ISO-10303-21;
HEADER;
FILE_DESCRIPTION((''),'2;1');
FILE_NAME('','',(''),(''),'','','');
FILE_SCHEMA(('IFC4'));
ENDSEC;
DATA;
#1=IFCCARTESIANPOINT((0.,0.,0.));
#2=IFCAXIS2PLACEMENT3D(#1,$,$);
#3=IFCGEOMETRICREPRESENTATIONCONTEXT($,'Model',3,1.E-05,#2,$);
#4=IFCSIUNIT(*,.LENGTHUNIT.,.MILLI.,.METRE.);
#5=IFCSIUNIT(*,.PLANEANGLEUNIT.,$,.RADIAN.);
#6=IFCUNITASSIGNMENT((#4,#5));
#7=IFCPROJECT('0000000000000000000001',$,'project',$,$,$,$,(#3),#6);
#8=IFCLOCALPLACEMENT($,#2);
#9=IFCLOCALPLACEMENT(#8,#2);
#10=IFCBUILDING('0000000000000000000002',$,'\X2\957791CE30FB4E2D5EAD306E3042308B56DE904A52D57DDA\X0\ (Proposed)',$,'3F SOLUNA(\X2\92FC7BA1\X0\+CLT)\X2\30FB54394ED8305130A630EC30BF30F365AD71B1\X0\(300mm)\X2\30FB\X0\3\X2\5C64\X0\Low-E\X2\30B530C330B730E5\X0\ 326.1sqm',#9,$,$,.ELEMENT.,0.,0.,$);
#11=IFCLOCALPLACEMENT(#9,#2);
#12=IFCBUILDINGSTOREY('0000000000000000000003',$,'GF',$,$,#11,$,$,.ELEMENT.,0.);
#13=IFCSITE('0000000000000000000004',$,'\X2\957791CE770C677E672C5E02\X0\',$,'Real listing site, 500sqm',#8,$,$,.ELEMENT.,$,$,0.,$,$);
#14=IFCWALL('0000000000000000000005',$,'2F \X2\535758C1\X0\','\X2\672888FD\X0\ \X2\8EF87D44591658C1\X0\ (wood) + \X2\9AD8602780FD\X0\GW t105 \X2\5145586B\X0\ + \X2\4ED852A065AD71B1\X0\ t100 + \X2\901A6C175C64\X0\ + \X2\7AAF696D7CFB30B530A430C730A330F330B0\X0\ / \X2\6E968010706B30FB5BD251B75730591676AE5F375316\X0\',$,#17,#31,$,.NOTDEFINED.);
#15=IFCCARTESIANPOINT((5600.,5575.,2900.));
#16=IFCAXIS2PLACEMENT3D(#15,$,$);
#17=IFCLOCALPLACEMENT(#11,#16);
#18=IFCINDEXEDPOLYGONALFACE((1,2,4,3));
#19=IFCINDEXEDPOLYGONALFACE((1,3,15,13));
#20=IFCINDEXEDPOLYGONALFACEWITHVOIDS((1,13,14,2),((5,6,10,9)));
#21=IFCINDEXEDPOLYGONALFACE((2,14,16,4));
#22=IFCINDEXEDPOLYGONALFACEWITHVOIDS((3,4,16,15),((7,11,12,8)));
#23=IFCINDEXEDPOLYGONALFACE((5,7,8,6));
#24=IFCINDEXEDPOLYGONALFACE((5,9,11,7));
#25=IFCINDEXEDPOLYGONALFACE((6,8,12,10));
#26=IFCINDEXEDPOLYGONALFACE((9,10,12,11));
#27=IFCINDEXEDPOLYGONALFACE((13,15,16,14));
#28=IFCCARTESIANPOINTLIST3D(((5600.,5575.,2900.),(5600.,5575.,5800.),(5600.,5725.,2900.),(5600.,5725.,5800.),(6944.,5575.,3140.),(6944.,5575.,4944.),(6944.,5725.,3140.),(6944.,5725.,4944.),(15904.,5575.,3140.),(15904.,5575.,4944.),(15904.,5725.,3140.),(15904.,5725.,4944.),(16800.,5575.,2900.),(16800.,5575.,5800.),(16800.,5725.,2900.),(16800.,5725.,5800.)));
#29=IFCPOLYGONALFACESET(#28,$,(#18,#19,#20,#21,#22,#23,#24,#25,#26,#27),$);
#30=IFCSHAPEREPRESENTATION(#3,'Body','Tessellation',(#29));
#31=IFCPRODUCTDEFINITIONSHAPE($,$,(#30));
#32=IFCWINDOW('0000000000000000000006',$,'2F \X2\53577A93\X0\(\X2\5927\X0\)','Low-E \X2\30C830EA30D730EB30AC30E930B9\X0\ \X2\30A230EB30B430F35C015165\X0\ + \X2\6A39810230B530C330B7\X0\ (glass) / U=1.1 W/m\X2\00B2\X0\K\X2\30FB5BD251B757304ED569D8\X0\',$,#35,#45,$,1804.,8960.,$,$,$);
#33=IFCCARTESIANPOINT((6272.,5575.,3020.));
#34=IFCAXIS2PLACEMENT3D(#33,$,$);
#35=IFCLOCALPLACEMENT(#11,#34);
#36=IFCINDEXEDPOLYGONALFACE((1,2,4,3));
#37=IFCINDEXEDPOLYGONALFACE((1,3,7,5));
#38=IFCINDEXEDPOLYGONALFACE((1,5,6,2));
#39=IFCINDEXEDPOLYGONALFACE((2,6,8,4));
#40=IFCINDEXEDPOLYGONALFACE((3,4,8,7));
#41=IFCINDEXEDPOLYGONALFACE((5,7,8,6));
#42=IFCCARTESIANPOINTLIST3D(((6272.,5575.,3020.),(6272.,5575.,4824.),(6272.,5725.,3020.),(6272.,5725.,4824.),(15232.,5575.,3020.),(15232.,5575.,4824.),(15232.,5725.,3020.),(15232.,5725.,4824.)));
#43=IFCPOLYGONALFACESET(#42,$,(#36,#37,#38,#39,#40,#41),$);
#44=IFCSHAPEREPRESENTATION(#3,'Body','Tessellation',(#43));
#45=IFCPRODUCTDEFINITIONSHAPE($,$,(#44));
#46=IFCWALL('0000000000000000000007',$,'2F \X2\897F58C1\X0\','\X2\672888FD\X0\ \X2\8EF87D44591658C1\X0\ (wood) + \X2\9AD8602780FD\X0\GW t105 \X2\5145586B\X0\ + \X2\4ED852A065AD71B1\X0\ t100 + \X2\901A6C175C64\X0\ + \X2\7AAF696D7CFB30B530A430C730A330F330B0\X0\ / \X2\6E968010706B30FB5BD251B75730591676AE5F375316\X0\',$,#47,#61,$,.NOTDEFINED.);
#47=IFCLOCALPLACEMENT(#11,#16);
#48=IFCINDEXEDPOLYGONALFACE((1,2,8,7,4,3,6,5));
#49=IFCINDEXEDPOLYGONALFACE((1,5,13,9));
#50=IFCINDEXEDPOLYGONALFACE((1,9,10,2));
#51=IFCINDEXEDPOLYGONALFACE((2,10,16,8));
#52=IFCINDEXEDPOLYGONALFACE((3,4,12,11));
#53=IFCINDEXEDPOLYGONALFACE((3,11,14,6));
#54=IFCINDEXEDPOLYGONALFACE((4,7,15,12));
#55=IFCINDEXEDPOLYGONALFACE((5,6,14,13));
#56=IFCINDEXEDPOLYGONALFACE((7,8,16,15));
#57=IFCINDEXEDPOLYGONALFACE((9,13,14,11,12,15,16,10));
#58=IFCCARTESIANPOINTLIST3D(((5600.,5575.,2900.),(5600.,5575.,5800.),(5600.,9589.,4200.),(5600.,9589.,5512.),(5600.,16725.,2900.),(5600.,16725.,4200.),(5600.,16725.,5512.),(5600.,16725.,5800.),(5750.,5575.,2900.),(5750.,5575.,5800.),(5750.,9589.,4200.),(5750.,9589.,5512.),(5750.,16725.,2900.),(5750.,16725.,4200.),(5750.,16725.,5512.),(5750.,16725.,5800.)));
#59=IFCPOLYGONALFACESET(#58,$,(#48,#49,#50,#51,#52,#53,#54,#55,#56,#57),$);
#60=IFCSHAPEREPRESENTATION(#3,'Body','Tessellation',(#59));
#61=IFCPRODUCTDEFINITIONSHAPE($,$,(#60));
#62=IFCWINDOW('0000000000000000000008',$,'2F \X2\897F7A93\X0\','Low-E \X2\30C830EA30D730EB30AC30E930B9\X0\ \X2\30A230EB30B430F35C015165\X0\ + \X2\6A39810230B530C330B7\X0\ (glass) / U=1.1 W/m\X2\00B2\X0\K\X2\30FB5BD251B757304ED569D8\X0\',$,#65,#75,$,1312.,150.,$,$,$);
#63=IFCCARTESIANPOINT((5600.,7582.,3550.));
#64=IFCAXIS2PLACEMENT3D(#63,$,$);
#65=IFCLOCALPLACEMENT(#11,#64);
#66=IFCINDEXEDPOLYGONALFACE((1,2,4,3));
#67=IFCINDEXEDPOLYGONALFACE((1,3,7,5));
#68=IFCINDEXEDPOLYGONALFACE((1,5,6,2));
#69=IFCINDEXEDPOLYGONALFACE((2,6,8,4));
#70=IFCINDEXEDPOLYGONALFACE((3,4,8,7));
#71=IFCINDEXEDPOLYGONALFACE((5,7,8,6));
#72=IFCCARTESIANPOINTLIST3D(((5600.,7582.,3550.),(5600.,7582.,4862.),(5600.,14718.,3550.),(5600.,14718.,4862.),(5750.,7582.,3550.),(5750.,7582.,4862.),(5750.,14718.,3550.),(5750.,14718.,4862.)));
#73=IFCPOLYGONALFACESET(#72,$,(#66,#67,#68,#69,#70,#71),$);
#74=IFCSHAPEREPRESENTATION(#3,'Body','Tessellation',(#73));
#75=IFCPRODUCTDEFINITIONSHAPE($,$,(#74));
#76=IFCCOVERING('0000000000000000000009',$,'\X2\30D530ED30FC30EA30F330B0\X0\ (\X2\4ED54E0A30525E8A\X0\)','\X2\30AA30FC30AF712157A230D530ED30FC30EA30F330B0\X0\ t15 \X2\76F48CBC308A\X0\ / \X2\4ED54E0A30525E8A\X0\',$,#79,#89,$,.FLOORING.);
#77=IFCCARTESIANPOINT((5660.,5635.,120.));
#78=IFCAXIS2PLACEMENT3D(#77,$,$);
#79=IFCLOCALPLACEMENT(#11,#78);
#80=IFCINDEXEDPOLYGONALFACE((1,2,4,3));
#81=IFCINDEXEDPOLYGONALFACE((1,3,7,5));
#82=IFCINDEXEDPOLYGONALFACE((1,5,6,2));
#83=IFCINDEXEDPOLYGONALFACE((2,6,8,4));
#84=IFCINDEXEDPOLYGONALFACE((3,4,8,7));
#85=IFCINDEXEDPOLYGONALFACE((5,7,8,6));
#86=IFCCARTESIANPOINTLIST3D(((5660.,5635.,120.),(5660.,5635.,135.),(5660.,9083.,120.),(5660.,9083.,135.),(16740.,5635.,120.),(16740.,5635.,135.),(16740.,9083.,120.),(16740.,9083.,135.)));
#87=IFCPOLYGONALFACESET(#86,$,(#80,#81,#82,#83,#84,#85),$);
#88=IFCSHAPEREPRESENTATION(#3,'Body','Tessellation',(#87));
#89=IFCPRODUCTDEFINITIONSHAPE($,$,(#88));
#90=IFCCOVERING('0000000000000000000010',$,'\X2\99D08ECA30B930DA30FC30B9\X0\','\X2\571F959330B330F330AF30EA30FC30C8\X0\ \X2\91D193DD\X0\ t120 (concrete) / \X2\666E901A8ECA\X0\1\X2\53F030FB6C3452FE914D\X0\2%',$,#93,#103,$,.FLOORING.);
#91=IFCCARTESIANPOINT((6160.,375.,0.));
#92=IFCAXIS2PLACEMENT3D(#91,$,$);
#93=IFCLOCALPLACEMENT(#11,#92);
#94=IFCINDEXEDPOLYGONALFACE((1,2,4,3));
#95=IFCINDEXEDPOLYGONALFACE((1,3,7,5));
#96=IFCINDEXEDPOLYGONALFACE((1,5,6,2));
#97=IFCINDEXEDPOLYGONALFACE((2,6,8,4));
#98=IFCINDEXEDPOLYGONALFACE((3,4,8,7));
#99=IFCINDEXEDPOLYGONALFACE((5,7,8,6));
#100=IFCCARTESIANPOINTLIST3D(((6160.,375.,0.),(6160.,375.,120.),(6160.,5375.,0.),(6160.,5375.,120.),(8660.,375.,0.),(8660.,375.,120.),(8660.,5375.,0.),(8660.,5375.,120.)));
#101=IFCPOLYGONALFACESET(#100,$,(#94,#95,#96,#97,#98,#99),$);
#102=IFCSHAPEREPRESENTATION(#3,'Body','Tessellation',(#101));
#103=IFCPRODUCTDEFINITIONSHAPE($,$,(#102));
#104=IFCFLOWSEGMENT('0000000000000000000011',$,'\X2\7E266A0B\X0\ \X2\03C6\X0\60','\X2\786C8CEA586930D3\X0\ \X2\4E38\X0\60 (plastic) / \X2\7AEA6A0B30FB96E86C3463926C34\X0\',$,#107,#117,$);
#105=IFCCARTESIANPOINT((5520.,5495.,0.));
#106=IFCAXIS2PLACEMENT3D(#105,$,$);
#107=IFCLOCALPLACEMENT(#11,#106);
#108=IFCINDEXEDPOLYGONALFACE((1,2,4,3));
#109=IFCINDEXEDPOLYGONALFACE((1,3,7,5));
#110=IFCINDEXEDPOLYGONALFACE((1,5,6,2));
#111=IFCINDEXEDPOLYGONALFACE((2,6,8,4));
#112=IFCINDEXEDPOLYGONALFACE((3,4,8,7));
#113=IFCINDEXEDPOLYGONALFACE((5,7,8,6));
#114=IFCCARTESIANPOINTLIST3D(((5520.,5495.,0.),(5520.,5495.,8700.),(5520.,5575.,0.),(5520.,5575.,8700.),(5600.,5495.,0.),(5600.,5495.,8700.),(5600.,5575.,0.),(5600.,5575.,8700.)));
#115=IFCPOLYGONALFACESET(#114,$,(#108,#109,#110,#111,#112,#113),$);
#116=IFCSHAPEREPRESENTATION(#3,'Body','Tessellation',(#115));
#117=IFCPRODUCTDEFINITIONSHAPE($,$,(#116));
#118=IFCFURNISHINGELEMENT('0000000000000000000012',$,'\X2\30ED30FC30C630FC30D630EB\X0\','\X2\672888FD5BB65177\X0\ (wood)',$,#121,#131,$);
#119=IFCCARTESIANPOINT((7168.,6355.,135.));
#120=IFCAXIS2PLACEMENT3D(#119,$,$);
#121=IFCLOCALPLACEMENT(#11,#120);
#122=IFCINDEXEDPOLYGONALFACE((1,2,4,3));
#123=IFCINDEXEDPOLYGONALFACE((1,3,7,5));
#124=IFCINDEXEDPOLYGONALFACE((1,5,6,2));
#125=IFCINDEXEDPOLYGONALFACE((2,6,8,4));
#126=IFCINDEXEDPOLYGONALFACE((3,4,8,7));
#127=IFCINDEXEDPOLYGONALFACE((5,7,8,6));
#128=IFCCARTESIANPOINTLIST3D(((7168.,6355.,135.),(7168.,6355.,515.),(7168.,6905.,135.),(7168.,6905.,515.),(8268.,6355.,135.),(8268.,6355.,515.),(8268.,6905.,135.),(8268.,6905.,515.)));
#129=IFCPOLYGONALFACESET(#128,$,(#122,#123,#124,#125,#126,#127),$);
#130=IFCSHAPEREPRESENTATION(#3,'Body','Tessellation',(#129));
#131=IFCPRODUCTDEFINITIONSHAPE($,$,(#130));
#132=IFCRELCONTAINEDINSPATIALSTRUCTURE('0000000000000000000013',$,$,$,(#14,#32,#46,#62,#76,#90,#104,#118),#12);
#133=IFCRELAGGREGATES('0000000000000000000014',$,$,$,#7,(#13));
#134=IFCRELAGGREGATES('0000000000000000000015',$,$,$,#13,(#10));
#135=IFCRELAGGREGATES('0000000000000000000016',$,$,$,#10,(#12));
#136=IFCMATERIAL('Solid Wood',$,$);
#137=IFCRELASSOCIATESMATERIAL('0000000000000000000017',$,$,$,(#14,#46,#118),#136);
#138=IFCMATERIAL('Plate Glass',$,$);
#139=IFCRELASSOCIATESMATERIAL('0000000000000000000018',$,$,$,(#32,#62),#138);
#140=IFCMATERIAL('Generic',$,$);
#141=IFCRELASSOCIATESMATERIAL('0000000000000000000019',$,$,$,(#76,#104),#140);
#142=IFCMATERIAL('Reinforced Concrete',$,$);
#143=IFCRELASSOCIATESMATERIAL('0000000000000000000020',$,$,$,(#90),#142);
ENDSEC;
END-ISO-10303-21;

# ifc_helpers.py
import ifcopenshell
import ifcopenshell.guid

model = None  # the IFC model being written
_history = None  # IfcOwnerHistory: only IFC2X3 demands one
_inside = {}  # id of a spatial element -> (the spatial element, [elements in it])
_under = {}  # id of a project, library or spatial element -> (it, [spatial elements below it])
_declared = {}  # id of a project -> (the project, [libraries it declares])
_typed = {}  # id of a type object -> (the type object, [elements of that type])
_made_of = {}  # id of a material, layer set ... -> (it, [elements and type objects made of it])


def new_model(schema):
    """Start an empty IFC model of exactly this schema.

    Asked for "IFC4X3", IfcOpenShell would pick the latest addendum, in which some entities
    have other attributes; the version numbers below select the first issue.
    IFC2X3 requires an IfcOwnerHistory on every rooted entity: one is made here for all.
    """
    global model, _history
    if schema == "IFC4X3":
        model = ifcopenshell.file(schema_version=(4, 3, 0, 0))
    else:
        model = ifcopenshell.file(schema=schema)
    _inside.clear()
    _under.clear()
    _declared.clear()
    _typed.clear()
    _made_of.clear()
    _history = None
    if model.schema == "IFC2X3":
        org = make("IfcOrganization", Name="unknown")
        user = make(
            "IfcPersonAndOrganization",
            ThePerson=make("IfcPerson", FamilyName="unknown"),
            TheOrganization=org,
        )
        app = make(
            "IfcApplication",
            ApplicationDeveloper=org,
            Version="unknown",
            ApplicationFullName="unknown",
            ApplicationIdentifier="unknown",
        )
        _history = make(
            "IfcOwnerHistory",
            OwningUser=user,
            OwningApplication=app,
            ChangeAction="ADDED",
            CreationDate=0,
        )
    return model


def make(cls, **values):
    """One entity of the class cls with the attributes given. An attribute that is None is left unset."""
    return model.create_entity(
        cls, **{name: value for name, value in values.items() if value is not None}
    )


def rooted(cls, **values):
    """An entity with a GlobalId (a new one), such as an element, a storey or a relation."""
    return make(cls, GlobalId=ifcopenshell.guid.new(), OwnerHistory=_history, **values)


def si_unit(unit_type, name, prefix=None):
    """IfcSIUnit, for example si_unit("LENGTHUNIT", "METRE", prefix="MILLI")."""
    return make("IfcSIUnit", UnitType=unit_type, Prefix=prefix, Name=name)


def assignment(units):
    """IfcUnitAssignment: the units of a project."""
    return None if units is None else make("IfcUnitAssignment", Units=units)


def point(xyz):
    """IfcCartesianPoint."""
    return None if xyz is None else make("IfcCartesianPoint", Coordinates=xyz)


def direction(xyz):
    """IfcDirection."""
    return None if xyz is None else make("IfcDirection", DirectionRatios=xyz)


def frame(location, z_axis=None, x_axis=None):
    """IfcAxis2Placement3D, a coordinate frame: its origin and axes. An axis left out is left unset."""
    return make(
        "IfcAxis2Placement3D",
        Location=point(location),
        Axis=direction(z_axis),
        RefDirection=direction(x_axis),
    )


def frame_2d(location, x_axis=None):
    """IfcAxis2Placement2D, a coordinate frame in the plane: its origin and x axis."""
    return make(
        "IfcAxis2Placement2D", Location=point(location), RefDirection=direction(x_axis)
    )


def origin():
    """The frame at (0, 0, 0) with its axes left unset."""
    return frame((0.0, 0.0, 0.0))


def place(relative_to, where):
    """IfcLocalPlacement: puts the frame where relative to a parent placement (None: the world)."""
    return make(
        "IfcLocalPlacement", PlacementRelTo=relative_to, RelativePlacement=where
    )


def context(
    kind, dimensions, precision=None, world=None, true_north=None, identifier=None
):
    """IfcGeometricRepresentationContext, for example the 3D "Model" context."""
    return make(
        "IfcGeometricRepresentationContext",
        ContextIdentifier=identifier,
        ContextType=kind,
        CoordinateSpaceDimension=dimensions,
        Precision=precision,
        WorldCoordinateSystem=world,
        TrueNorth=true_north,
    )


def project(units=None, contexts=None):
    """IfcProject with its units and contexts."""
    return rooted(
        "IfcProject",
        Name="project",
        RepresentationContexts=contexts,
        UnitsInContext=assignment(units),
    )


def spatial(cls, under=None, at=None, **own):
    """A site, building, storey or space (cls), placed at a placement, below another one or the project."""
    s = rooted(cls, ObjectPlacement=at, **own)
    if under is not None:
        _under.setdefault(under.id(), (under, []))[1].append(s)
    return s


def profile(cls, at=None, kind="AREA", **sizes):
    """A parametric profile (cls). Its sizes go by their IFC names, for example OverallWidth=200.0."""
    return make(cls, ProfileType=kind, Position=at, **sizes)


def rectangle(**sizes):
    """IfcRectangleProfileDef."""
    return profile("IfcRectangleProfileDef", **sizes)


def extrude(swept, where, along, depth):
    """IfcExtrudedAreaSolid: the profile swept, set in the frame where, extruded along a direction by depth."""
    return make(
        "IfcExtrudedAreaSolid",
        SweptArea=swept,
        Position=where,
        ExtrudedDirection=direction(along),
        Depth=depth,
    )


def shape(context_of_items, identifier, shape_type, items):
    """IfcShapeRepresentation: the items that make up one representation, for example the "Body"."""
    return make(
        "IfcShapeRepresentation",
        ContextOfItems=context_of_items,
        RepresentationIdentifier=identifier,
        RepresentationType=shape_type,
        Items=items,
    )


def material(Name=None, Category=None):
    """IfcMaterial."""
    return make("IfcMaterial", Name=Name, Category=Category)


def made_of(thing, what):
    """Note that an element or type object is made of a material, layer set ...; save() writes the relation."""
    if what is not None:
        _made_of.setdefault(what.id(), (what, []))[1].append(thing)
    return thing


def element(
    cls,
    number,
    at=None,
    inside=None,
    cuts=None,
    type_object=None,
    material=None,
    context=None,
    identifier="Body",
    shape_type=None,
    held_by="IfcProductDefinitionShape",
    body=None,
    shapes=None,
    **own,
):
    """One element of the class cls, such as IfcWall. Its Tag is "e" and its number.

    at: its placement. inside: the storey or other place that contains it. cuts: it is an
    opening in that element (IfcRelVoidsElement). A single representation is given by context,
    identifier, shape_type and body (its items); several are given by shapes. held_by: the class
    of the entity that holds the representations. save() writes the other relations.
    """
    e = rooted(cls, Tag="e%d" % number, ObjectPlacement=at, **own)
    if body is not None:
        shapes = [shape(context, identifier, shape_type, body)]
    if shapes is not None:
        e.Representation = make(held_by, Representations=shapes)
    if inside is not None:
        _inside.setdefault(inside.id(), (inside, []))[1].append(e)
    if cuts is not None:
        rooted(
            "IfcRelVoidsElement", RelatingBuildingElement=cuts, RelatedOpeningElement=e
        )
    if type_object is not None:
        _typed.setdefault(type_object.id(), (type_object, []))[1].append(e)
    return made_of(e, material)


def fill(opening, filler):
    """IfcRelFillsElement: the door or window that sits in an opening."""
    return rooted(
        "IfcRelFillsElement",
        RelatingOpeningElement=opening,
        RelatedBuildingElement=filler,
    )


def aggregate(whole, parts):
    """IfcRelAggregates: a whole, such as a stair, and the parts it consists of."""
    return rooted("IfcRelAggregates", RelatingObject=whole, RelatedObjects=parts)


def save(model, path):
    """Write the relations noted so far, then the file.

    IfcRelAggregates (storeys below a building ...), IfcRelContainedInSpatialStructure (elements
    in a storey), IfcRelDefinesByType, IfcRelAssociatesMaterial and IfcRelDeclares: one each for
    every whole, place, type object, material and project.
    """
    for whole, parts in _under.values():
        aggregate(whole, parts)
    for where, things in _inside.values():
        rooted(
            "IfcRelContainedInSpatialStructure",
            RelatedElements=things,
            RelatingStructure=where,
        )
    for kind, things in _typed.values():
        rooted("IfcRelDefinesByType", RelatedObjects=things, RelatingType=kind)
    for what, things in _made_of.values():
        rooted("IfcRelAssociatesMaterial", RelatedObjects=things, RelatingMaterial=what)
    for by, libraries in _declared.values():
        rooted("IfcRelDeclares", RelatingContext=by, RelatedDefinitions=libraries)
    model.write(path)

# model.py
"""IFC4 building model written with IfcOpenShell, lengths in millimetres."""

from ifc_helpers import new_model, si_unit, frame, frame_2d, origin, place, context, project, spatial, rectangle, extrude, material, element, fill, save


model = new_model("IFC4")

# Units and contexts
model_context = context("Model", 3, precision=1e-05, world=origin())
ifc_project = project(units=[si_unit("LENGTHUNIT", "METRE", prefix="MILLI"), si_unit("PLANEANGLEUNIT", "RADIAN")], contexts=[model_context])

# Site, building, storey
site_placement = place(None, origin())
site = spatial("IfcSite", under=ifc_project, at=site_placement, Name="長野県松本市", ObjectType="Real listing site, 500sqm", CompositionType="ELEMENT", RefElevation=0.0)
building_placement = place(site_placement, origin())
building = spatial("IfcBuilding", under=site, at=building_placement, Name="長野・中庭のある回遊動線 (Proposed)", ObjectType="3F SOLUNA(鋼管+CLT)・吹付けウレタン断熱(300mm)・3層Low-Eサッシュ 326.1sqm", CompositionType="ELEMENT", ElevationOfRefHeight=0.0, ElevationOfTerrain=0.0)
storey_placement = place(building_placement, origin())
storey = spatial("IfcBuildingStorey", under=building, at=storey_placement, Name="GF", CompositionType="ELEMENT", Elevation=0.0)

# Shared definitions
ifc_material_1 = material(Name="Solid Wood")

# Shared definitions
ifc_material_2 = material(Name="Reinforced Concrete")

# Shared definitions
ifc_material_3 = material(Name="Plate Glass")

# Walls, openings, windows
wall_1_placement = place(storey_placement, frame((5600.0, 5575.0, 2900.0)))
wall_1 = element("IfcWall", 1, at=wall_1_placement, inside=storey, material=ifc_material_1, Name="2F 南壁", Description="木製 軸組外壁 (wood) + 高性能GW t105 充填 + 付加断熱 t100 + 通気層 + 窯業系サイディング / 準耐火・寒冷地外皮強化", PredefinedType="NOTDEFINED", context=model_context, shape_type="SweptSolid", body=[
    extrude(rectangle(XDim=11200.0, YDim=150.0, at=frame_2d((5600.0, 75.0))), frame((5600.0, 5575.0, 2900.0)), (0.0, 0.0, 1.0), 2900.0),
])
opening_1_placement = place(storey_placement, frame((6272.0, 5575.0, 3020.0)))
opening_1 = element("IfcOpeningElement", 2, at=opening_1_placement, cuts=wall_1, PredefinedType="NOTDEFINED", context=model_context, shape_type="SweptSolid", body=[
    extrude(rectangle(XDim=8960.0, YDim=150.0, at=frame_2d((4480.0, 75.0))), frame((6272.0, 5575.0, 3020.0)), (0.0, 0.0, 1.0), 1804.0),
])
window_1_placement = place(storey_placement, frame((6272.0, 5575.0, 3020.0)))
window_1 = element("IfcWindow", 3, at=window_1_placement, inside=storey, material=ifc_material_3, Name="2F 南窓(大)", Description="Low-E トリプルガラス アルゴン封入 + 樹脂サッシ (glass) / U=1.1 W/m²K・寒冷地仕様", OverallHeight=1804.0, OverallWidth=8960.0, context=model_context, shape_type="SweptSolid", body=[
    extrude(rectangle(XDim=8960.0, YDim=150.0, at=frame_2d((4480.0, 75.0))), frame((6272.0, 5575.0, 3020.0)), (0.0, 0.0, 1.0), 1804.0),
])
fill(opening_1, window_1)
wall_2_placement = place(storey_placement, frame((5600.0, 5575.0, 2900.0)))
wall_2 = element("IfcWall", 4, at=wall_2_placement, inside=storey, material=ifc_material_1, Name="2F 西壁", Description="木製 軸組外壁 (wood) + 高性能GW t105 充填 + 付加断熱 t100 + 通気層 + 窯業系サイディング / 準耐火・寒冷地外皮強化", PredefinedType="NOTDEFINED", context=model_context, shape_type="SweptSolid", body=[
    extrude(rectangle(XDim=150.0, YDim=11150.0, at=frame_2d((75.0, 5575.0))), frame((5600.0, 5575.0, 2900.0)), (0.0, 0.0, 1.0), 2900.0),
])
opening_2_placement = place(storey_placement, frame((5600.0, 7582.0, 3550.0)))
opening_2 = element("IfcOpeningElement", 5, at=opening_2_placement, cuts=wall_2, PredefinedType="NOTDEFINED", context=model_context, shape_type="SweptSolid", body=[
    extrude(rectangle(XDim=150.0, YDim=7136.0, at=frame_2d((75.0, 3568.0))), frame((5600.0, 7582.0, 3550.0)), (0.0, 0.0, 1.0), 1312.0),
])
window_2_placement = place(storey_placement, frame((5600.0, 7582.0, 3550.0)))
window_2 = element("IfcWindow", 6, at=window_2_placement, inside=storey, material=ifc_material_3, Name="2F 西窓", Description="Low-E トリプルガラス アルゴン封入 + 樹脂サッシ (glass) / U=1.1 W/m²K・寒冷地仕様", OverallHeight=1312.0, OverallWidth=150.0, context=model_context, shape_type="SweptSolid", body=[
    extrude(rectangle(XDim=150.0, YDim=7136.0, at=frame_2d((75.0, 3568.0))), frame((5600.0, 7582.0, 3550.0)), (0.0, 0.0, 1.0), 1312.0),
])
fill(opening_2, window_2)

# Coverings
ifc_material_4 = material(Name="Generic")
covering_1_placement = place(storey_placement, frame((5660.0, 5635.0, 120.0)))
element("IfcCovering", 7, at=covering_1_placement, inside=storey, material=ifc_material_4, Name="フローリング (仕上げ床)", Description="オーク無垢フローリング t15 直貼り / 仕上げ床", PredefinedType="FLOORING", context=model_context, shape_type="SweptSolid", body=[
    extrude(rectangle(XDim=11080.0, YDim=3448.0, at=frame_2d((5540.0, 1724.0))), frame((5660.0, 5635.0, 120.0)), (0.0, 0.0, 1.0), 15.0),
])
covering_2_placement = place(storey_placement, frame((6160.0, 375.0, 0.0)))
element("IfcCovering", 8, at=covering_2_placement, inside=storey, material=ifc_material_2, Name="駐車スペース", Description="土間コンクリート 金鏝 t120 (concrete) / 普通車1台・水勾配2%", PredefinedType="FLOORING", context=model_context, shape_type="SweptSolid", body=[
    extrude(rectangle(XDim=2500.0, YDim=5000.0, at=frame_2d((1250.0, 2500.0))), frame((6160.0, 375.0, 0.0)), (0.0, 0.0, 1.0), 120.0),
])

# Flow segment
flow_segment_placement = place(storey_placement, frame((5520.0, 5495.0, 0.0)))
element("IfcFlowSegment", 9, at=flow_segment_placement, inside=storey, material=ifc_material_4, Name="縦樋 φ60", Description="硬質塩ビ 丸60 (plastic) / 竪樋・雨水排水", context=model_context, shape_type="SweptSolid", body=[
    extrude(rectangle(XDim=80.0, YDim=80.0, at=frame_2d((40.0, 40.0))), frame((5520.0, 5495.0, 0.0)), (0.0, 0.0, 1.0), 8700.0),
])

# Furnishing element
furnishing_placement = place(storey_placement, frame((7168.0, 6355.0, 135.0)))
element("IfcFurnishingElement", 10, at=furnishing_placement, inside=storey, material=ifc_material_1, Name="ローテーブル", Description="木製家具 (wood)", context=model_context, shape_type="SweptSolid", body=[
    extrude(rectangle(XDim=1100.0, YDim=550.0, at=frame_2d((550.0, 275.0))), frame((7168.0, 6355.0, 135.0)), (0.0, 0.0, 1.0), 380.0),
])

save(model, "model.ifc")
